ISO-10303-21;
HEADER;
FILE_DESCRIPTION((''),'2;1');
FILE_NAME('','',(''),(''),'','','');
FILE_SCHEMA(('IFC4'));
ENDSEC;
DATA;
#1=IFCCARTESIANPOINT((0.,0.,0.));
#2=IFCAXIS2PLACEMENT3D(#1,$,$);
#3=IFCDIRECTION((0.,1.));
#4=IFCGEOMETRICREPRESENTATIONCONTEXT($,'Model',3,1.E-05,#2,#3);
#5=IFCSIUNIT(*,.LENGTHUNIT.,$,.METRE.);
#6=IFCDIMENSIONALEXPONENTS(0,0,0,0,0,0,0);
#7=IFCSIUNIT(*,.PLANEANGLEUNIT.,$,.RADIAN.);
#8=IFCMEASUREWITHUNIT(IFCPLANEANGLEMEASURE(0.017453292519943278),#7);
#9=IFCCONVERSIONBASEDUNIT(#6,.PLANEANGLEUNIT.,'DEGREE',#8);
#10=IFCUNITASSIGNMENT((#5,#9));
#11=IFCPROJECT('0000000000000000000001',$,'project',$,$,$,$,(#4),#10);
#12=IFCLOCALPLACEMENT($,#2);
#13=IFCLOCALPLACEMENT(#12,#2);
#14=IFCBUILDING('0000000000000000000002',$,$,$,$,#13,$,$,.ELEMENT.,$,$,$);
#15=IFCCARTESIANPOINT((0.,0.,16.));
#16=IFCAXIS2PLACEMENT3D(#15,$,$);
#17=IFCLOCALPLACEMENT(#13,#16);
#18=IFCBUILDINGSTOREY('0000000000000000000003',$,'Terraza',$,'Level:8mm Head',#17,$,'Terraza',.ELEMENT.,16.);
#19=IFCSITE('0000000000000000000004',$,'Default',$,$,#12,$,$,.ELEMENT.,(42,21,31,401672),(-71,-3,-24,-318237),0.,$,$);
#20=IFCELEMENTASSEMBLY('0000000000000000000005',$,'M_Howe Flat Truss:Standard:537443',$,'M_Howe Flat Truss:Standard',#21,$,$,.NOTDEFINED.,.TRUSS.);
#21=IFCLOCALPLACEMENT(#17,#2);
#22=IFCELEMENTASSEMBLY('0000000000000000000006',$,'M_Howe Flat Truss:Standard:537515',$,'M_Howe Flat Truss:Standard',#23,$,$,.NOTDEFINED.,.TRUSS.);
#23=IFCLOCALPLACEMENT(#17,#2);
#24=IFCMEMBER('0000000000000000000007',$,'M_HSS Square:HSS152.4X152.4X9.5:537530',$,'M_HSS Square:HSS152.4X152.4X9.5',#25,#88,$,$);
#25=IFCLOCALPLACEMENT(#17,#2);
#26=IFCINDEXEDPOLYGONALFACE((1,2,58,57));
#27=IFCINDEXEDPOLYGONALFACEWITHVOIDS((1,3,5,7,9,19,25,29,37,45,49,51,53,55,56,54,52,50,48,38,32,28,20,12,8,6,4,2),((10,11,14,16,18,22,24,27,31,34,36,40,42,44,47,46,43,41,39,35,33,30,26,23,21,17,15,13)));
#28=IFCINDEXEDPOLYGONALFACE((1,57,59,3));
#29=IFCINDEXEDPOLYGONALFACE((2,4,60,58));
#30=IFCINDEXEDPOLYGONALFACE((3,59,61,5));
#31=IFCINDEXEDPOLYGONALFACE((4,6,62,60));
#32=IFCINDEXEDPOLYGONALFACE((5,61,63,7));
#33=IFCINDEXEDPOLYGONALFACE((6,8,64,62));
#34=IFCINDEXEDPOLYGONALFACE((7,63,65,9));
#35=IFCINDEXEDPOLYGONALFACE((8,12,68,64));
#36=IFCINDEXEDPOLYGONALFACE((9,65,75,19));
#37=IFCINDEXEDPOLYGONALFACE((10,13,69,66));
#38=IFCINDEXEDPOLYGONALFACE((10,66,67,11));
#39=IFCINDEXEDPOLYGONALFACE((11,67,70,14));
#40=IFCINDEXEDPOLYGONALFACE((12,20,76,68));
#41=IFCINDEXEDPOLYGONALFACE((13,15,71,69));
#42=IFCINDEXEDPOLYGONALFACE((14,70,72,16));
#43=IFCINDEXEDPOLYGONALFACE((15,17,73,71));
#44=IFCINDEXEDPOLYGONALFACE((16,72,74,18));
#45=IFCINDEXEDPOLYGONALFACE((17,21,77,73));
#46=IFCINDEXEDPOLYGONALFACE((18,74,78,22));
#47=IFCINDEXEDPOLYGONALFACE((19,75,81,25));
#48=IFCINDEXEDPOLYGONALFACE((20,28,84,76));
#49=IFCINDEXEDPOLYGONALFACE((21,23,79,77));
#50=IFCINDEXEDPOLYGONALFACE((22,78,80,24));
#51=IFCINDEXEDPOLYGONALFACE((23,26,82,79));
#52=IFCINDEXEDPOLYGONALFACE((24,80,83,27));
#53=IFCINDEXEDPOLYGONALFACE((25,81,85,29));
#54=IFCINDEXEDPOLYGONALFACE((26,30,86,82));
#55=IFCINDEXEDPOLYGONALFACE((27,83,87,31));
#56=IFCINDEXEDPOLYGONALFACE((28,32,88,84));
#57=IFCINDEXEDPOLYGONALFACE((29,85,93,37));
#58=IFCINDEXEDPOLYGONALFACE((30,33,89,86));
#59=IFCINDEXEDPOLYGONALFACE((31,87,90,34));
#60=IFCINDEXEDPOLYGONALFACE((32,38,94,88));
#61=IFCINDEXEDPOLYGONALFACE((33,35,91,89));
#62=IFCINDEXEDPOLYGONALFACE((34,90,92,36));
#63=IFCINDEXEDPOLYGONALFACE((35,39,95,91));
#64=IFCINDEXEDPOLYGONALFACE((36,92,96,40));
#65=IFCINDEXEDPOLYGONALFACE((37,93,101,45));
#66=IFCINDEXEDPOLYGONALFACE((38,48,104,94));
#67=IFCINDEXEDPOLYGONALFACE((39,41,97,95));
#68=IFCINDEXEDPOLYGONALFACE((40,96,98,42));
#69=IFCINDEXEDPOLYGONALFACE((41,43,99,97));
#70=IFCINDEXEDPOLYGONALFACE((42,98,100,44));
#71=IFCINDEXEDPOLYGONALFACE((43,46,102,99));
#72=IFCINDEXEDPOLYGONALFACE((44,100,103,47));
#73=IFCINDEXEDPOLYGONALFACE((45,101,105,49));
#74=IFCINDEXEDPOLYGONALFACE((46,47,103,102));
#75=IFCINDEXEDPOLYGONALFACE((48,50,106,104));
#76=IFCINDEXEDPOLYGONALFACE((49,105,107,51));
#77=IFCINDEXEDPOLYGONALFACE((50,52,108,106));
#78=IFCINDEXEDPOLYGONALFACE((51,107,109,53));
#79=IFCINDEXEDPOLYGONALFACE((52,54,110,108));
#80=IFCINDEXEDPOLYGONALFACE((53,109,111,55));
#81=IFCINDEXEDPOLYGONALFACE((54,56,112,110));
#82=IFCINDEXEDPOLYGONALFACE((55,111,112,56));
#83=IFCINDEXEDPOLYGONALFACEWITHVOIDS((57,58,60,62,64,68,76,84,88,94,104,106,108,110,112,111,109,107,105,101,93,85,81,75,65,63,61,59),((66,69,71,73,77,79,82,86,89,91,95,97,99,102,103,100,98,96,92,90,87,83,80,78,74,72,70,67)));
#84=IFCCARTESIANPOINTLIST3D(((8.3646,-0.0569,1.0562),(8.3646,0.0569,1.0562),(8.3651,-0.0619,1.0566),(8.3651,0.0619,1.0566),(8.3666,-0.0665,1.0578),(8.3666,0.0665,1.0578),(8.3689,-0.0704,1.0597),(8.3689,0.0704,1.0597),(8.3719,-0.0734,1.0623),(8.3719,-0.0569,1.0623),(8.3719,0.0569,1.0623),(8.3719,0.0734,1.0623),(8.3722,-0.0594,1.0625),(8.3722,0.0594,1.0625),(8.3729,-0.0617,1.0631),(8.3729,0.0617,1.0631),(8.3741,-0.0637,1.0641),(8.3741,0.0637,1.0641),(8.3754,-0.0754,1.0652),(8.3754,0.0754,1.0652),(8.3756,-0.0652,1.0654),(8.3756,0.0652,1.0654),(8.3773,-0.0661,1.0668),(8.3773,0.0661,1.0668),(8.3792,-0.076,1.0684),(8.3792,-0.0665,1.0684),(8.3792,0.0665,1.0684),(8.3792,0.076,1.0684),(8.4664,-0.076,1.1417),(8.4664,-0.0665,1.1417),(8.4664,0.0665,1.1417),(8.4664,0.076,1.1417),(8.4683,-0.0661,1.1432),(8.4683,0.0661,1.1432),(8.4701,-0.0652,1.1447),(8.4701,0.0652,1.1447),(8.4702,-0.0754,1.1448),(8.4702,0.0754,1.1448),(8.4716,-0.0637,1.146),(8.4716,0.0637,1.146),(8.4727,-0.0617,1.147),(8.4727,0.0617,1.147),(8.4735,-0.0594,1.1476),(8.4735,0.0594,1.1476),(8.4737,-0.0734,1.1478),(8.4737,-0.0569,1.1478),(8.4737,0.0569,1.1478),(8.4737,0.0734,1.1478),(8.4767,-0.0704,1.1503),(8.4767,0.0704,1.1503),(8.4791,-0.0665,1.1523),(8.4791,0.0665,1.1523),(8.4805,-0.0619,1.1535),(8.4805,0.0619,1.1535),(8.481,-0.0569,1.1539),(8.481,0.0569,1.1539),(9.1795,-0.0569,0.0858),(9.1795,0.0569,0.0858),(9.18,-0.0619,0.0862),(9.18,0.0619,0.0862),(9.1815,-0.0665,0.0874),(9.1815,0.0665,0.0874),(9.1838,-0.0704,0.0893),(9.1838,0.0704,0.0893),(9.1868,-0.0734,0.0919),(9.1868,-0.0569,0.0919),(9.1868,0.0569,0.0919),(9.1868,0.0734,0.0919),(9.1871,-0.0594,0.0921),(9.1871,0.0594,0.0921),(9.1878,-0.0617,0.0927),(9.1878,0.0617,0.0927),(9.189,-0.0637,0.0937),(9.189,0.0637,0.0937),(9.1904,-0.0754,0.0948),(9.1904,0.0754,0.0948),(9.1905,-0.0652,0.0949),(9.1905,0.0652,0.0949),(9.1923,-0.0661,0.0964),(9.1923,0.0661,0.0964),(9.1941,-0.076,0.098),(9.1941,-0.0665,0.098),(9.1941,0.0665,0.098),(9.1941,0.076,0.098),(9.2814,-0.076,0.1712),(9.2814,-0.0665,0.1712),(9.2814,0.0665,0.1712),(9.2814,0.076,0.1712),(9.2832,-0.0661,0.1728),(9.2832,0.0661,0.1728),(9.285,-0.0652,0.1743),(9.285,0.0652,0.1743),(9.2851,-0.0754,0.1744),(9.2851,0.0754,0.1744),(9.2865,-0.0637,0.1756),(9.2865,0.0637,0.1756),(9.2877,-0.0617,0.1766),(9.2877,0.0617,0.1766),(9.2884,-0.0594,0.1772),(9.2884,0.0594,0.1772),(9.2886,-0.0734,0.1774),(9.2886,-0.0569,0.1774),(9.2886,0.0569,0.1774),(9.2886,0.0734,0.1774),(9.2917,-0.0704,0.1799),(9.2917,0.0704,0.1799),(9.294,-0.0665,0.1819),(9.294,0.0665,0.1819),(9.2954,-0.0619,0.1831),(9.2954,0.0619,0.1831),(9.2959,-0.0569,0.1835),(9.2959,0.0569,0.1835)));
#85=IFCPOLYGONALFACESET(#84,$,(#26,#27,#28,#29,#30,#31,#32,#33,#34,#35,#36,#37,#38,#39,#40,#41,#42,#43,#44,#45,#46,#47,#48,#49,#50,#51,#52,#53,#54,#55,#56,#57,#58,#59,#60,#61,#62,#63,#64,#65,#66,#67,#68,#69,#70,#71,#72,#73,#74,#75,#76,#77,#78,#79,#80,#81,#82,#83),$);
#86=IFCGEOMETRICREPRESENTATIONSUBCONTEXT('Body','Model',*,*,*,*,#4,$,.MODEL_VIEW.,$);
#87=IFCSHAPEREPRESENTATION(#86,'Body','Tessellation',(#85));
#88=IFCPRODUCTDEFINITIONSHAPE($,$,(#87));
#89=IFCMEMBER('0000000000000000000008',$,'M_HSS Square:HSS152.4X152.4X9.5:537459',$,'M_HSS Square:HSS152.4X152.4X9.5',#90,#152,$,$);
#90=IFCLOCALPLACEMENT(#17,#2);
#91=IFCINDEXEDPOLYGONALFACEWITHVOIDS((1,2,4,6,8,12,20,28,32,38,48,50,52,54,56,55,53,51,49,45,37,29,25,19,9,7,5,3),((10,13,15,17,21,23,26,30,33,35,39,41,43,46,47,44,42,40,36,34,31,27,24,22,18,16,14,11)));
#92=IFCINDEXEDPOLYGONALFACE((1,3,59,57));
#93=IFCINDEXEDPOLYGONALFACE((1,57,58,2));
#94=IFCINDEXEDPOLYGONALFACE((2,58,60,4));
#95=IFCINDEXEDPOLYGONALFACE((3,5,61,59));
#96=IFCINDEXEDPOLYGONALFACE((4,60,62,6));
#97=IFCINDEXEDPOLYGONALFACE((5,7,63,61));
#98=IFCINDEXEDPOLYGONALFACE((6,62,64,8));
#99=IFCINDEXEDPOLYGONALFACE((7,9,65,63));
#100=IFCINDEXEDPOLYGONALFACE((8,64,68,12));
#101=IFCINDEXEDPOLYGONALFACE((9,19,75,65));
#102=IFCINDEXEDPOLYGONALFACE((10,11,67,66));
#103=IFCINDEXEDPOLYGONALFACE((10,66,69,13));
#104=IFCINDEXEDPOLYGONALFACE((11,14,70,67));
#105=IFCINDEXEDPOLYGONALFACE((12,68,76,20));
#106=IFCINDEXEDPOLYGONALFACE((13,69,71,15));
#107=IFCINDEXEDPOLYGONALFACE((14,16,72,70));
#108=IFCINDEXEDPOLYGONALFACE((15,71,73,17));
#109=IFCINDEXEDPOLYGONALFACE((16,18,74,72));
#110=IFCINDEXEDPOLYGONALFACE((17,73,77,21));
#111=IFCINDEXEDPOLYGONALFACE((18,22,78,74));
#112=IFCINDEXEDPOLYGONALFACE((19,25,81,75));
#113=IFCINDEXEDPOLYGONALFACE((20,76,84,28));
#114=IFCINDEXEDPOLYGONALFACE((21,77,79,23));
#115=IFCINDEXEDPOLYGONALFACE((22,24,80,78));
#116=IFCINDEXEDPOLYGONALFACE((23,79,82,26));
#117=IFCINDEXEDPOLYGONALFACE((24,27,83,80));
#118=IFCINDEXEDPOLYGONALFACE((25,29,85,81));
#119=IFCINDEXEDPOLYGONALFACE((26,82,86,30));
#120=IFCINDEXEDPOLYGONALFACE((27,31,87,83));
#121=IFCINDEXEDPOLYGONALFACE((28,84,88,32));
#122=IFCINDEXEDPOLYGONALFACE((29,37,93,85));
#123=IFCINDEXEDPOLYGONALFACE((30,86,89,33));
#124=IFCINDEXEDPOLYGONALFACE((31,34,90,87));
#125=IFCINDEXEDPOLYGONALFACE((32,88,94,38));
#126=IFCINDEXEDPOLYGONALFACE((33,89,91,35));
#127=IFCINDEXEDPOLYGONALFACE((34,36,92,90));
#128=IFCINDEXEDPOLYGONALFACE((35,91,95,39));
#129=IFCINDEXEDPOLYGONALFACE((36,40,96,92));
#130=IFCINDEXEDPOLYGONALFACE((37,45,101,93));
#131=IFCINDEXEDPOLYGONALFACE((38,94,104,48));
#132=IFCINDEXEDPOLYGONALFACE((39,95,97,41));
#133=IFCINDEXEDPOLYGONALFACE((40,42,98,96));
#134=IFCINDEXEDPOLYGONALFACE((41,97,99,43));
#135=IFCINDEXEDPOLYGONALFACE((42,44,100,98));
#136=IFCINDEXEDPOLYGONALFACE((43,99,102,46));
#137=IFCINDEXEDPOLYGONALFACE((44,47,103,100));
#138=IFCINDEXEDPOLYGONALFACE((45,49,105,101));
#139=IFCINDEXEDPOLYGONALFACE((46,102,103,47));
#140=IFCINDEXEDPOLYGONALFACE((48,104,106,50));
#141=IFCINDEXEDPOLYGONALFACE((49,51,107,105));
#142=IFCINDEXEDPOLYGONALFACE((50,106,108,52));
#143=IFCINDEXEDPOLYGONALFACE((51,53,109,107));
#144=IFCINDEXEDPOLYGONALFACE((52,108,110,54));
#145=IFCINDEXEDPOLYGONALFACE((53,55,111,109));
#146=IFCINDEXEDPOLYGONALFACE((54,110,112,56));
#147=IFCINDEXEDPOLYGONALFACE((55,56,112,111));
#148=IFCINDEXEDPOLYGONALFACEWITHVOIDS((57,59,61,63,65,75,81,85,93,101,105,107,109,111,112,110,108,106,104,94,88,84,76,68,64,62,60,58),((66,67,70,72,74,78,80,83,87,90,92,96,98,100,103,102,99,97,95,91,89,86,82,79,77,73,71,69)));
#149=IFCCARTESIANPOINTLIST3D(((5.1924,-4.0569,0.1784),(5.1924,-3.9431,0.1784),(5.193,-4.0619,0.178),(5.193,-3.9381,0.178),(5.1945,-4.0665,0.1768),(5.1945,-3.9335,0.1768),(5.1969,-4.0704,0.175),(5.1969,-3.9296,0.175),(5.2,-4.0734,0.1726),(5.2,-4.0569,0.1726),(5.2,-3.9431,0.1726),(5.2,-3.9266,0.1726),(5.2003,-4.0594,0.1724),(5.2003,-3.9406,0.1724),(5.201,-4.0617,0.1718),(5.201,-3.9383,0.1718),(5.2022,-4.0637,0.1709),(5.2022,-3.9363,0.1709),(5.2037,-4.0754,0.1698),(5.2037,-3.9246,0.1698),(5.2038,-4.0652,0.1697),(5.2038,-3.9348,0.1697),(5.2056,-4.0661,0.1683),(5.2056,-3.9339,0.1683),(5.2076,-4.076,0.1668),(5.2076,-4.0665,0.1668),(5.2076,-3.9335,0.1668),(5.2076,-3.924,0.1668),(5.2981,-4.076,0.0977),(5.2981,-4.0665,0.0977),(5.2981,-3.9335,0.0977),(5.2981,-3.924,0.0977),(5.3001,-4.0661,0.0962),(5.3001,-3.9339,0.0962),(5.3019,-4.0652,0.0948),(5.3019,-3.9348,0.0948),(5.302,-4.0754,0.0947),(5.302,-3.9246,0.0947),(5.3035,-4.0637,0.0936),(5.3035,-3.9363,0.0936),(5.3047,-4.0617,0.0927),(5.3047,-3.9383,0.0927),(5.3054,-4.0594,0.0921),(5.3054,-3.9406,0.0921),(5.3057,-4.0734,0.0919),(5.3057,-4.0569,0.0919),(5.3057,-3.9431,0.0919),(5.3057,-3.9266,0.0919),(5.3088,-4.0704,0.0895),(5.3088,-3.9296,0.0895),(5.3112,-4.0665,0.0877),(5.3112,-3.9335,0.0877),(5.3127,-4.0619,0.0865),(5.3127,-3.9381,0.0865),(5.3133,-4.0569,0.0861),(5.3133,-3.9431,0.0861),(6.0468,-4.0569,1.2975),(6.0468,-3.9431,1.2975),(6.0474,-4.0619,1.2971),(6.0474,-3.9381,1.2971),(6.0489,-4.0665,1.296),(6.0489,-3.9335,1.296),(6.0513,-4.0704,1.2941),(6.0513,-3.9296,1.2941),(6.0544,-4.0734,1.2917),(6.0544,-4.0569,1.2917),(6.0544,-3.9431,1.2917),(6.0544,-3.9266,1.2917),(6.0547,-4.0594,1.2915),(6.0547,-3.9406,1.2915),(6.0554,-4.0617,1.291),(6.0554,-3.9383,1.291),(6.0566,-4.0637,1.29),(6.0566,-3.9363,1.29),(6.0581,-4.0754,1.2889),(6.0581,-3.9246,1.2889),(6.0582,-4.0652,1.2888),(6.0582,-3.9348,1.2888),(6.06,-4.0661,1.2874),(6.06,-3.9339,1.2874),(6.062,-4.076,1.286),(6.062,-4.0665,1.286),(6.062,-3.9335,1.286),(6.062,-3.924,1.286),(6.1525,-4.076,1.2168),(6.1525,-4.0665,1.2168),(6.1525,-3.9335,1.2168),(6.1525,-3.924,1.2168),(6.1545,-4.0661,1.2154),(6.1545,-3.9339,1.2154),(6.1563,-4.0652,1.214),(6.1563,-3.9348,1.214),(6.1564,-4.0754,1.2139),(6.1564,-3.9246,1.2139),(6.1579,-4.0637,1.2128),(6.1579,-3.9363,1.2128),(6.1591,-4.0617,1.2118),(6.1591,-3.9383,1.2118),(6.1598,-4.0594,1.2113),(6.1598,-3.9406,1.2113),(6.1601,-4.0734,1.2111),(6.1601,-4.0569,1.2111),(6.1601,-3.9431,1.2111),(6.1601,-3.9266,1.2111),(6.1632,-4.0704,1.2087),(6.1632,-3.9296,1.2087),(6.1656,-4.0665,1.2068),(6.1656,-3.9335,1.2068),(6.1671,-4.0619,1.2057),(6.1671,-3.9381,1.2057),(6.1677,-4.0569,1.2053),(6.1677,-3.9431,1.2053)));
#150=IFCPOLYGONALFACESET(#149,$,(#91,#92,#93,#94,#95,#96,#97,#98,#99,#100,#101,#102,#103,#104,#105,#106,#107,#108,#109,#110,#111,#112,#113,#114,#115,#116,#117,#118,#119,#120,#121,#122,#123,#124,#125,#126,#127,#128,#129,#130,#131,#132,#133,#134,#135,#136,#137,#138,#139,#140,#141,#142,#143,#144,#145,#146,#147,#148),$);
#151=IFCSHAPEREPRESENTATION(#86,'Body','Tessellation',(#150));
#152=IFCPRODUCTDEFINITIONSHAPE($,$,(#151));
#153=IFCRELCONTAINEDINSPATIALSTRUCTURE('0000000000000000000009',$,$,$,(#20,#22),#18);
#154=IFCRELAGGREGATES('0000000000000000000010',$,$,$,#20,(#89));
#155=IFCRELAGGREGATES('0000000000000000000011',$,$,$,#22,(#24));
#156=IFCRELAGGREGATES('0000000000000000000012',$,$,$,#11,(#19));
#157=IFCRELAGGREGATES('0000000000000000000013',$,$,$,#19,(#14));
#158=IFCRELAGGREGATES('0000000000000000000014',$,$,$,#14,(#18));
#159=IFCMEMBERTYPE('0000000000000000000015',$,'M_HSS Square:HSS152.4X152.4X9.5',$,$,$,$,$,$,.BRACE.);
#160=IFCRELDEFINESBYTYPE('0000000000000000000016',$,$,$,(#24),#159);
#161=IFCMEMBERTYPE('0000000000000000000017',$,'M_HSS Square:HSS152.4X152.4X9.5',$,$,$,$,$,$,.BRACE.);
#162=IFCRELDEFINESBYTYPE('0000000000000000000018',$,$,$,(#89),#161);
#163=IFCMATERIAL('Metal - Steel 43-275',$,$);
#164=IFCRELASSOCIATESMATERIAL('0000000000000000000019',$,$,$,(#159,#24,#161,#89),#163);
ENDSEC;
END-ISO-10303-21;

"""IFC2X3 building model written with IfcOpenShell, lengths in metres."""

from ifc_helpers import new_model, entity, si_unit, converted_unit, direction, frame, frame_2d, origin, place, context, subcontext, project, spatial, polyline, circle_curve, parameter, trimmed, segment, composite_curve, outline, extrude, source, transform, mapped, material, type_object, type_shapes, element, aggregate, save


model = new_model("IFC2X3")

# Units and contexts
model_context = context("Model", 3, precision=1e-05, world=origin(), true_north=direction((0.0, 1.0)))
body_context = subcontext(model_context, "Body", "Model", "MODEL_VIEW")
ifc_project = project(units=[si_unit("LENGTHUNIT", "METRE"), converted_unit("PLANEANGLEUNIT", "DEGREE", entity("IfcPlaneAngleMeasure", 0.017453292519943278), si_unit("PLANEANGLEUNIT", "RADIAN"), dimensions=[0, 0, 0, 0, 0, 0, 0])], contexts=[model_context])

# Site, building, storey
site_placement = place(None, origin())
site = spatial("IfcSite", under=ifc_project, at=site_placement, Name="Default", CompositionType="ELEMENT", RefLatitude=(42, 21, 31, 401672), RefLongitude=(-71, -3, -24, -318237), RefElevation=0.0)
building_placement = place(site_placement, origin())
building = spatial("IfcBuilding", under=site, at=building_placement, CompositionType="ELEMENT")
storey_placement = place(building_placement, frame((0.0, 0.0, 16.0)))
storey = spatial("IfcBuildingStorey", under=building, at=storey_placement, Name="Terraza", ObjectType="Level:8mm Head", LongName="Terraza", CompositionType="ELEMENT", Elevation=16.0)

# Element assemblies
ifc_material_1 = material(Name="Metal - Steel 43-275")
assembly_1_placement = place(storey_placement, origin())
assembly_1 = element("IfcElementAssembly", 1, at=assembly_1_placement, inside=storey, Name="M_Howe Flat Truss:Standard:537443", ObjectType="M_Howe Flat Truss:Standard", AssemblyPlace="NOTDEFINED", PredefinedType="TRUSS")
assembly_2_placement = place(storey_placement, origin())
assembly_2 = element("IfcElementAssembly", 2, at=assembly_2_placement, inside=storey, Name="M_Howe Flat Truss:Standard:537515", ObjectType="M_Howe Flat Truss:Standard", AssemblyPlace="NOTDEFINED", PredefinedType="TRUSS")

# Members
member_type_1 = type_object("IfcMemberType", Name="M_HSS Square:HSS152.4X152.4X9.5", PredefinedType="BRACE", material=ifc_material_1)
shared_shape_1 = source(origin(), body_context, "Body", "SweptSolid", [
    extrude(outline(composite_curve([segment(polyline([(-0.0569, -0.076), (0.0569, -0.076)]), True, "CONTINUOUS"), segment(trimmed(circle_curve(frame_2d((0.0569, -0.0569), x_axis=(0.0, 1.0)), 0.0191), [parameter(180.0)], [parameter(270.0)], True, "PARAMETER"), True, "CONTINUOUS"), segment(polyline([(0.076, -0.0569), (0.076, 0.0569)]), True, "CONTINUOUS"), segment(trimmed(circle_curve(frame_2d((0.0569, 0.0569), x_axis=(0.0, 1.0)), 0.0191), [parameter(270.0)], [parameter(0.0)], True, "PARAMETER"), True, "CONTINUOUS"), segment(polyline([(0.0569, 0.076), (-0.0569, 0.076)]), True, "CONTINUOUS"), segment(trimmed(circle_curve(frame_2d((-0.0569, 0.0569), x_axis=(0.0, 1.0)), 0.0191), [parameter(0.0)], [parameter(90.0)], True, "PARAMETER"), True, "CONTINUOUS"), segment(polyline([(-0.076, 0.0569), (-0.076, -0.0569)]), True, "CONTINUOUS"), segment(trimmed(circle_curve(frame_2d((-0.0569, -0.0569), x_axis=(0.0, 1.0)), 0.0191), [parameter(90.0)], [parameter(180.0)], True, "PARAMETER"), True, "CONTINUOUS")], self_intersect=False), holes=[composite_curve([segment(trimmed(circle_curve(frame_2d((-0.0569, 0.0569), x_axis=(0.0, 1.0)), 0.0095), [parameter(360.0)], [parameter(90.0)], True, "PARAMETER"), False, "CONTINUOUS"), segment(polyline([(-0.0569, 0.0665), (0.0569, 0.0665)]), True, "CONTINUOUS"), segment(trimmed(circle_curve(frame_2d((0.0569, 0.0569), x_axis=(0.0, 1.0)), 0.0095), [parameter(270.0)], [parameter(360.0)], True, "PARAMETER"), False, "CONTINUOUS"), segment(polyline([(0.0665, 0.0569), (0.0665, -0.0569)]), True, "CONTINUOUS"), segment(trimmed(circle_curve(frame_2d((0.0569, -0.0569), x_axis=(0.0, 1.0)), 0.0095), [parameter(180.0)], [parameter(270.0)], True, "PARAMETER"), False, "CONTINUOUS"), segment(polyline([(0.0569, -0.0665), (-0.0569, -0.0665)]), True, "CONTINUOUS"), segment(trimmed(circle_curve(frame_2d((-0.0569, -0.0569), x_axis=(0.0, 1.0)), 0.0095), [parameter(90.0)], [parameter(180.0)], True, "PARAMETER"), False, "CONTINUOUS"), segment(polyline([(-0.0665, -0.0569), (-0.0665, 0.0569)]), True, "CONTINUOUS")], self_intersect=False)]), frame((-0.6269, 0.0, 0.0), z_axis=(1.0, 0.0, 0.0), x_axis=(0.0, 0.0, -1.0)), (0.0, 0.0, 1.0), 1.2672),
])
type_shapes(member_type_1, [shared_shape_1])
member_1_placement = place(assembly_2_placement, frame((8.8259, 0.0, 0.625), z_axis=(-0.765786, 0.0, -0.643096), x_axis=(0.643096, 0.0, -0.765786)))
member_1 = element("IfcMember", 3, at=member_1_placement, type_object=member_type_1, material=ifc_material_1, Name="M_HSS Square:HSS152.4X152.4X9.5:537530", ObjectType="M_HSS Square:HSS152.4X152.4X9.5", context=body_context, shape_type="MappedRepresentation", body=[
    mapped(shared_shape_1, transform((0.0, 0.0, 0.0), scale=1.0)),
])
member_type_2 = type_object("IfcMemberType", Name="M_HSS Square:HSS152.4X152.4X9.5", PredefinedType="BRACE", material=ifc_material_1)
shared_shape_2 = source(origin(), body_context, "Body", "SweptSolid", [
    extrude(outline(composite_curve([segment(polyline([(-0.0569, -0.076), (0.0569, -0.076)]), True, "CONTINUOUS"), segment(trimmed(circle_curve(frame_2d((0.0569, -0.0569), x_axis=(0.0, 1.0)), 0.0191), [parameter(180.0)], [parameter(270.0)], True, "PARAMETER"), True, "CONTINUOUS"), segment(polyline([(0.076, -0.0569), (0.076, 0.0569)]), True, "CONTINUOUS"), segment(trimmed(circle_curve(frame_2d((0.0569, 0.0569), x_axis=(0.0, 1.0)), 0.0191), [parameter(270.0)], [parameter(0.0)], True, "PARAMETER"), True, "CONTINUOUS"), segment(polyline([(0.0569, 0.076), (-0.0569, 0.076)]), True, "CONTINUOUS"), segment(trimmed(circle_curve(frame_2d((-0.0569, 0.0569), x_axis=(0.0, 1.0)), 0.0191), [parameter(0.0)], [parameter(90.0)], True, "PARAMETER"), True, "CONTINUOUS"), segment(polyline([(-0.076, 0.0569), (-0.076, -0.0569)]), True, "CONTINUOUS"), segment(trimmed(circle_curve(frame_2d((-0.0569, -0.0569), x_axis=(0.0, 1.0)), 0.0191), [parameter(90.0)], [parameter(180.0)], True, "PARAMETER"), True, "CONTINUOUS")], self_intersect=False), holes=[composite_curve([segment(trimmed(circle_curve(frame_2d((-0.0569, 0.0569), x_axis=(0.0, 1.0)), 0.0095), [parameter(360.0)], [parameter(90.0)], True, "PARAMETER"), False, "CONTINUOUS"), segment(polyline([(-0.0569, 0.0665), (0.0569, 0.0665)]), True, "CONTINUOUS"), segment(trimmed(circle_curve(frame_2d((0.0569, 0.0569), x_axis=(0.0, 1.0)), 0.0095), [parameter(270.0)], [parameter(360.0)], True, "PARAMETER"), False, "CONTINUOUS"), segment(polyline([(0.0665, 0.0569), (0.0665, -0.0569)]), True, "CONTINUOUS"), segment(trimmed(circle_curve(frame_2d((0.0569, -0.0569), x_axis=(0.0, 1.0)), 0.0095), [parameter(180.0)], [parameter(270.0)], True, "PARAMETER"), False, "CONTINUOUS"), segment(polyline([(0.0569, -0.0665), (-0.0569, -0.0665)]), True, "CONTINUOUS"), segment(trimmed(circle_curve(frame_2d((-0.0569, -0.0569), x_axis=(0.0, 1.0)), 0.0095), [parameter(90.0)], [parameter(180.0)], True, "PARAMETER"), False, "CONTINUOUS"), segment(polyline([(-0.0665, -0.0569), (-0.0665, 0.0569)]), True, "CONTINUOUS")], self_intersect=False)]), frame((-0.6986, 0.0, 0.0), z_axis=(1.0, 0.0, 0.0), x_axis=(0.0, 0.0, -1.0)), (0.0, 0.0, 1.0), 1.408),
])
type_shapes(member_type_2, [shared_shape_2])
member_2_placement = place(assembly_1_placement, frame((5.6767, -4.0, 0.6875), z_axis=(0.794843, 0.0, -0.606815), x_axis=(0.606815, 0.0, 0.794843)))
member_2 = element("IfcMember", 4, at=member_2_placement, type_object=member_type_2, material=ifc_material_1, Name="M_HSS Square:HSS152.4X152.4X9.5:537459", ObjectType="M_HSS Square:HSS152.4X152.4X9.5", context=body_context, shape_type="MappedRepresentation", body=[
    mapped(shared_shape_2, transform((0.0, 0.0, 0.0), scale=1.0)),
])
aggregate(assembly_1, [member_2])
aggregate(assembly_2, [member_1])

save(model, "model.ifc")
